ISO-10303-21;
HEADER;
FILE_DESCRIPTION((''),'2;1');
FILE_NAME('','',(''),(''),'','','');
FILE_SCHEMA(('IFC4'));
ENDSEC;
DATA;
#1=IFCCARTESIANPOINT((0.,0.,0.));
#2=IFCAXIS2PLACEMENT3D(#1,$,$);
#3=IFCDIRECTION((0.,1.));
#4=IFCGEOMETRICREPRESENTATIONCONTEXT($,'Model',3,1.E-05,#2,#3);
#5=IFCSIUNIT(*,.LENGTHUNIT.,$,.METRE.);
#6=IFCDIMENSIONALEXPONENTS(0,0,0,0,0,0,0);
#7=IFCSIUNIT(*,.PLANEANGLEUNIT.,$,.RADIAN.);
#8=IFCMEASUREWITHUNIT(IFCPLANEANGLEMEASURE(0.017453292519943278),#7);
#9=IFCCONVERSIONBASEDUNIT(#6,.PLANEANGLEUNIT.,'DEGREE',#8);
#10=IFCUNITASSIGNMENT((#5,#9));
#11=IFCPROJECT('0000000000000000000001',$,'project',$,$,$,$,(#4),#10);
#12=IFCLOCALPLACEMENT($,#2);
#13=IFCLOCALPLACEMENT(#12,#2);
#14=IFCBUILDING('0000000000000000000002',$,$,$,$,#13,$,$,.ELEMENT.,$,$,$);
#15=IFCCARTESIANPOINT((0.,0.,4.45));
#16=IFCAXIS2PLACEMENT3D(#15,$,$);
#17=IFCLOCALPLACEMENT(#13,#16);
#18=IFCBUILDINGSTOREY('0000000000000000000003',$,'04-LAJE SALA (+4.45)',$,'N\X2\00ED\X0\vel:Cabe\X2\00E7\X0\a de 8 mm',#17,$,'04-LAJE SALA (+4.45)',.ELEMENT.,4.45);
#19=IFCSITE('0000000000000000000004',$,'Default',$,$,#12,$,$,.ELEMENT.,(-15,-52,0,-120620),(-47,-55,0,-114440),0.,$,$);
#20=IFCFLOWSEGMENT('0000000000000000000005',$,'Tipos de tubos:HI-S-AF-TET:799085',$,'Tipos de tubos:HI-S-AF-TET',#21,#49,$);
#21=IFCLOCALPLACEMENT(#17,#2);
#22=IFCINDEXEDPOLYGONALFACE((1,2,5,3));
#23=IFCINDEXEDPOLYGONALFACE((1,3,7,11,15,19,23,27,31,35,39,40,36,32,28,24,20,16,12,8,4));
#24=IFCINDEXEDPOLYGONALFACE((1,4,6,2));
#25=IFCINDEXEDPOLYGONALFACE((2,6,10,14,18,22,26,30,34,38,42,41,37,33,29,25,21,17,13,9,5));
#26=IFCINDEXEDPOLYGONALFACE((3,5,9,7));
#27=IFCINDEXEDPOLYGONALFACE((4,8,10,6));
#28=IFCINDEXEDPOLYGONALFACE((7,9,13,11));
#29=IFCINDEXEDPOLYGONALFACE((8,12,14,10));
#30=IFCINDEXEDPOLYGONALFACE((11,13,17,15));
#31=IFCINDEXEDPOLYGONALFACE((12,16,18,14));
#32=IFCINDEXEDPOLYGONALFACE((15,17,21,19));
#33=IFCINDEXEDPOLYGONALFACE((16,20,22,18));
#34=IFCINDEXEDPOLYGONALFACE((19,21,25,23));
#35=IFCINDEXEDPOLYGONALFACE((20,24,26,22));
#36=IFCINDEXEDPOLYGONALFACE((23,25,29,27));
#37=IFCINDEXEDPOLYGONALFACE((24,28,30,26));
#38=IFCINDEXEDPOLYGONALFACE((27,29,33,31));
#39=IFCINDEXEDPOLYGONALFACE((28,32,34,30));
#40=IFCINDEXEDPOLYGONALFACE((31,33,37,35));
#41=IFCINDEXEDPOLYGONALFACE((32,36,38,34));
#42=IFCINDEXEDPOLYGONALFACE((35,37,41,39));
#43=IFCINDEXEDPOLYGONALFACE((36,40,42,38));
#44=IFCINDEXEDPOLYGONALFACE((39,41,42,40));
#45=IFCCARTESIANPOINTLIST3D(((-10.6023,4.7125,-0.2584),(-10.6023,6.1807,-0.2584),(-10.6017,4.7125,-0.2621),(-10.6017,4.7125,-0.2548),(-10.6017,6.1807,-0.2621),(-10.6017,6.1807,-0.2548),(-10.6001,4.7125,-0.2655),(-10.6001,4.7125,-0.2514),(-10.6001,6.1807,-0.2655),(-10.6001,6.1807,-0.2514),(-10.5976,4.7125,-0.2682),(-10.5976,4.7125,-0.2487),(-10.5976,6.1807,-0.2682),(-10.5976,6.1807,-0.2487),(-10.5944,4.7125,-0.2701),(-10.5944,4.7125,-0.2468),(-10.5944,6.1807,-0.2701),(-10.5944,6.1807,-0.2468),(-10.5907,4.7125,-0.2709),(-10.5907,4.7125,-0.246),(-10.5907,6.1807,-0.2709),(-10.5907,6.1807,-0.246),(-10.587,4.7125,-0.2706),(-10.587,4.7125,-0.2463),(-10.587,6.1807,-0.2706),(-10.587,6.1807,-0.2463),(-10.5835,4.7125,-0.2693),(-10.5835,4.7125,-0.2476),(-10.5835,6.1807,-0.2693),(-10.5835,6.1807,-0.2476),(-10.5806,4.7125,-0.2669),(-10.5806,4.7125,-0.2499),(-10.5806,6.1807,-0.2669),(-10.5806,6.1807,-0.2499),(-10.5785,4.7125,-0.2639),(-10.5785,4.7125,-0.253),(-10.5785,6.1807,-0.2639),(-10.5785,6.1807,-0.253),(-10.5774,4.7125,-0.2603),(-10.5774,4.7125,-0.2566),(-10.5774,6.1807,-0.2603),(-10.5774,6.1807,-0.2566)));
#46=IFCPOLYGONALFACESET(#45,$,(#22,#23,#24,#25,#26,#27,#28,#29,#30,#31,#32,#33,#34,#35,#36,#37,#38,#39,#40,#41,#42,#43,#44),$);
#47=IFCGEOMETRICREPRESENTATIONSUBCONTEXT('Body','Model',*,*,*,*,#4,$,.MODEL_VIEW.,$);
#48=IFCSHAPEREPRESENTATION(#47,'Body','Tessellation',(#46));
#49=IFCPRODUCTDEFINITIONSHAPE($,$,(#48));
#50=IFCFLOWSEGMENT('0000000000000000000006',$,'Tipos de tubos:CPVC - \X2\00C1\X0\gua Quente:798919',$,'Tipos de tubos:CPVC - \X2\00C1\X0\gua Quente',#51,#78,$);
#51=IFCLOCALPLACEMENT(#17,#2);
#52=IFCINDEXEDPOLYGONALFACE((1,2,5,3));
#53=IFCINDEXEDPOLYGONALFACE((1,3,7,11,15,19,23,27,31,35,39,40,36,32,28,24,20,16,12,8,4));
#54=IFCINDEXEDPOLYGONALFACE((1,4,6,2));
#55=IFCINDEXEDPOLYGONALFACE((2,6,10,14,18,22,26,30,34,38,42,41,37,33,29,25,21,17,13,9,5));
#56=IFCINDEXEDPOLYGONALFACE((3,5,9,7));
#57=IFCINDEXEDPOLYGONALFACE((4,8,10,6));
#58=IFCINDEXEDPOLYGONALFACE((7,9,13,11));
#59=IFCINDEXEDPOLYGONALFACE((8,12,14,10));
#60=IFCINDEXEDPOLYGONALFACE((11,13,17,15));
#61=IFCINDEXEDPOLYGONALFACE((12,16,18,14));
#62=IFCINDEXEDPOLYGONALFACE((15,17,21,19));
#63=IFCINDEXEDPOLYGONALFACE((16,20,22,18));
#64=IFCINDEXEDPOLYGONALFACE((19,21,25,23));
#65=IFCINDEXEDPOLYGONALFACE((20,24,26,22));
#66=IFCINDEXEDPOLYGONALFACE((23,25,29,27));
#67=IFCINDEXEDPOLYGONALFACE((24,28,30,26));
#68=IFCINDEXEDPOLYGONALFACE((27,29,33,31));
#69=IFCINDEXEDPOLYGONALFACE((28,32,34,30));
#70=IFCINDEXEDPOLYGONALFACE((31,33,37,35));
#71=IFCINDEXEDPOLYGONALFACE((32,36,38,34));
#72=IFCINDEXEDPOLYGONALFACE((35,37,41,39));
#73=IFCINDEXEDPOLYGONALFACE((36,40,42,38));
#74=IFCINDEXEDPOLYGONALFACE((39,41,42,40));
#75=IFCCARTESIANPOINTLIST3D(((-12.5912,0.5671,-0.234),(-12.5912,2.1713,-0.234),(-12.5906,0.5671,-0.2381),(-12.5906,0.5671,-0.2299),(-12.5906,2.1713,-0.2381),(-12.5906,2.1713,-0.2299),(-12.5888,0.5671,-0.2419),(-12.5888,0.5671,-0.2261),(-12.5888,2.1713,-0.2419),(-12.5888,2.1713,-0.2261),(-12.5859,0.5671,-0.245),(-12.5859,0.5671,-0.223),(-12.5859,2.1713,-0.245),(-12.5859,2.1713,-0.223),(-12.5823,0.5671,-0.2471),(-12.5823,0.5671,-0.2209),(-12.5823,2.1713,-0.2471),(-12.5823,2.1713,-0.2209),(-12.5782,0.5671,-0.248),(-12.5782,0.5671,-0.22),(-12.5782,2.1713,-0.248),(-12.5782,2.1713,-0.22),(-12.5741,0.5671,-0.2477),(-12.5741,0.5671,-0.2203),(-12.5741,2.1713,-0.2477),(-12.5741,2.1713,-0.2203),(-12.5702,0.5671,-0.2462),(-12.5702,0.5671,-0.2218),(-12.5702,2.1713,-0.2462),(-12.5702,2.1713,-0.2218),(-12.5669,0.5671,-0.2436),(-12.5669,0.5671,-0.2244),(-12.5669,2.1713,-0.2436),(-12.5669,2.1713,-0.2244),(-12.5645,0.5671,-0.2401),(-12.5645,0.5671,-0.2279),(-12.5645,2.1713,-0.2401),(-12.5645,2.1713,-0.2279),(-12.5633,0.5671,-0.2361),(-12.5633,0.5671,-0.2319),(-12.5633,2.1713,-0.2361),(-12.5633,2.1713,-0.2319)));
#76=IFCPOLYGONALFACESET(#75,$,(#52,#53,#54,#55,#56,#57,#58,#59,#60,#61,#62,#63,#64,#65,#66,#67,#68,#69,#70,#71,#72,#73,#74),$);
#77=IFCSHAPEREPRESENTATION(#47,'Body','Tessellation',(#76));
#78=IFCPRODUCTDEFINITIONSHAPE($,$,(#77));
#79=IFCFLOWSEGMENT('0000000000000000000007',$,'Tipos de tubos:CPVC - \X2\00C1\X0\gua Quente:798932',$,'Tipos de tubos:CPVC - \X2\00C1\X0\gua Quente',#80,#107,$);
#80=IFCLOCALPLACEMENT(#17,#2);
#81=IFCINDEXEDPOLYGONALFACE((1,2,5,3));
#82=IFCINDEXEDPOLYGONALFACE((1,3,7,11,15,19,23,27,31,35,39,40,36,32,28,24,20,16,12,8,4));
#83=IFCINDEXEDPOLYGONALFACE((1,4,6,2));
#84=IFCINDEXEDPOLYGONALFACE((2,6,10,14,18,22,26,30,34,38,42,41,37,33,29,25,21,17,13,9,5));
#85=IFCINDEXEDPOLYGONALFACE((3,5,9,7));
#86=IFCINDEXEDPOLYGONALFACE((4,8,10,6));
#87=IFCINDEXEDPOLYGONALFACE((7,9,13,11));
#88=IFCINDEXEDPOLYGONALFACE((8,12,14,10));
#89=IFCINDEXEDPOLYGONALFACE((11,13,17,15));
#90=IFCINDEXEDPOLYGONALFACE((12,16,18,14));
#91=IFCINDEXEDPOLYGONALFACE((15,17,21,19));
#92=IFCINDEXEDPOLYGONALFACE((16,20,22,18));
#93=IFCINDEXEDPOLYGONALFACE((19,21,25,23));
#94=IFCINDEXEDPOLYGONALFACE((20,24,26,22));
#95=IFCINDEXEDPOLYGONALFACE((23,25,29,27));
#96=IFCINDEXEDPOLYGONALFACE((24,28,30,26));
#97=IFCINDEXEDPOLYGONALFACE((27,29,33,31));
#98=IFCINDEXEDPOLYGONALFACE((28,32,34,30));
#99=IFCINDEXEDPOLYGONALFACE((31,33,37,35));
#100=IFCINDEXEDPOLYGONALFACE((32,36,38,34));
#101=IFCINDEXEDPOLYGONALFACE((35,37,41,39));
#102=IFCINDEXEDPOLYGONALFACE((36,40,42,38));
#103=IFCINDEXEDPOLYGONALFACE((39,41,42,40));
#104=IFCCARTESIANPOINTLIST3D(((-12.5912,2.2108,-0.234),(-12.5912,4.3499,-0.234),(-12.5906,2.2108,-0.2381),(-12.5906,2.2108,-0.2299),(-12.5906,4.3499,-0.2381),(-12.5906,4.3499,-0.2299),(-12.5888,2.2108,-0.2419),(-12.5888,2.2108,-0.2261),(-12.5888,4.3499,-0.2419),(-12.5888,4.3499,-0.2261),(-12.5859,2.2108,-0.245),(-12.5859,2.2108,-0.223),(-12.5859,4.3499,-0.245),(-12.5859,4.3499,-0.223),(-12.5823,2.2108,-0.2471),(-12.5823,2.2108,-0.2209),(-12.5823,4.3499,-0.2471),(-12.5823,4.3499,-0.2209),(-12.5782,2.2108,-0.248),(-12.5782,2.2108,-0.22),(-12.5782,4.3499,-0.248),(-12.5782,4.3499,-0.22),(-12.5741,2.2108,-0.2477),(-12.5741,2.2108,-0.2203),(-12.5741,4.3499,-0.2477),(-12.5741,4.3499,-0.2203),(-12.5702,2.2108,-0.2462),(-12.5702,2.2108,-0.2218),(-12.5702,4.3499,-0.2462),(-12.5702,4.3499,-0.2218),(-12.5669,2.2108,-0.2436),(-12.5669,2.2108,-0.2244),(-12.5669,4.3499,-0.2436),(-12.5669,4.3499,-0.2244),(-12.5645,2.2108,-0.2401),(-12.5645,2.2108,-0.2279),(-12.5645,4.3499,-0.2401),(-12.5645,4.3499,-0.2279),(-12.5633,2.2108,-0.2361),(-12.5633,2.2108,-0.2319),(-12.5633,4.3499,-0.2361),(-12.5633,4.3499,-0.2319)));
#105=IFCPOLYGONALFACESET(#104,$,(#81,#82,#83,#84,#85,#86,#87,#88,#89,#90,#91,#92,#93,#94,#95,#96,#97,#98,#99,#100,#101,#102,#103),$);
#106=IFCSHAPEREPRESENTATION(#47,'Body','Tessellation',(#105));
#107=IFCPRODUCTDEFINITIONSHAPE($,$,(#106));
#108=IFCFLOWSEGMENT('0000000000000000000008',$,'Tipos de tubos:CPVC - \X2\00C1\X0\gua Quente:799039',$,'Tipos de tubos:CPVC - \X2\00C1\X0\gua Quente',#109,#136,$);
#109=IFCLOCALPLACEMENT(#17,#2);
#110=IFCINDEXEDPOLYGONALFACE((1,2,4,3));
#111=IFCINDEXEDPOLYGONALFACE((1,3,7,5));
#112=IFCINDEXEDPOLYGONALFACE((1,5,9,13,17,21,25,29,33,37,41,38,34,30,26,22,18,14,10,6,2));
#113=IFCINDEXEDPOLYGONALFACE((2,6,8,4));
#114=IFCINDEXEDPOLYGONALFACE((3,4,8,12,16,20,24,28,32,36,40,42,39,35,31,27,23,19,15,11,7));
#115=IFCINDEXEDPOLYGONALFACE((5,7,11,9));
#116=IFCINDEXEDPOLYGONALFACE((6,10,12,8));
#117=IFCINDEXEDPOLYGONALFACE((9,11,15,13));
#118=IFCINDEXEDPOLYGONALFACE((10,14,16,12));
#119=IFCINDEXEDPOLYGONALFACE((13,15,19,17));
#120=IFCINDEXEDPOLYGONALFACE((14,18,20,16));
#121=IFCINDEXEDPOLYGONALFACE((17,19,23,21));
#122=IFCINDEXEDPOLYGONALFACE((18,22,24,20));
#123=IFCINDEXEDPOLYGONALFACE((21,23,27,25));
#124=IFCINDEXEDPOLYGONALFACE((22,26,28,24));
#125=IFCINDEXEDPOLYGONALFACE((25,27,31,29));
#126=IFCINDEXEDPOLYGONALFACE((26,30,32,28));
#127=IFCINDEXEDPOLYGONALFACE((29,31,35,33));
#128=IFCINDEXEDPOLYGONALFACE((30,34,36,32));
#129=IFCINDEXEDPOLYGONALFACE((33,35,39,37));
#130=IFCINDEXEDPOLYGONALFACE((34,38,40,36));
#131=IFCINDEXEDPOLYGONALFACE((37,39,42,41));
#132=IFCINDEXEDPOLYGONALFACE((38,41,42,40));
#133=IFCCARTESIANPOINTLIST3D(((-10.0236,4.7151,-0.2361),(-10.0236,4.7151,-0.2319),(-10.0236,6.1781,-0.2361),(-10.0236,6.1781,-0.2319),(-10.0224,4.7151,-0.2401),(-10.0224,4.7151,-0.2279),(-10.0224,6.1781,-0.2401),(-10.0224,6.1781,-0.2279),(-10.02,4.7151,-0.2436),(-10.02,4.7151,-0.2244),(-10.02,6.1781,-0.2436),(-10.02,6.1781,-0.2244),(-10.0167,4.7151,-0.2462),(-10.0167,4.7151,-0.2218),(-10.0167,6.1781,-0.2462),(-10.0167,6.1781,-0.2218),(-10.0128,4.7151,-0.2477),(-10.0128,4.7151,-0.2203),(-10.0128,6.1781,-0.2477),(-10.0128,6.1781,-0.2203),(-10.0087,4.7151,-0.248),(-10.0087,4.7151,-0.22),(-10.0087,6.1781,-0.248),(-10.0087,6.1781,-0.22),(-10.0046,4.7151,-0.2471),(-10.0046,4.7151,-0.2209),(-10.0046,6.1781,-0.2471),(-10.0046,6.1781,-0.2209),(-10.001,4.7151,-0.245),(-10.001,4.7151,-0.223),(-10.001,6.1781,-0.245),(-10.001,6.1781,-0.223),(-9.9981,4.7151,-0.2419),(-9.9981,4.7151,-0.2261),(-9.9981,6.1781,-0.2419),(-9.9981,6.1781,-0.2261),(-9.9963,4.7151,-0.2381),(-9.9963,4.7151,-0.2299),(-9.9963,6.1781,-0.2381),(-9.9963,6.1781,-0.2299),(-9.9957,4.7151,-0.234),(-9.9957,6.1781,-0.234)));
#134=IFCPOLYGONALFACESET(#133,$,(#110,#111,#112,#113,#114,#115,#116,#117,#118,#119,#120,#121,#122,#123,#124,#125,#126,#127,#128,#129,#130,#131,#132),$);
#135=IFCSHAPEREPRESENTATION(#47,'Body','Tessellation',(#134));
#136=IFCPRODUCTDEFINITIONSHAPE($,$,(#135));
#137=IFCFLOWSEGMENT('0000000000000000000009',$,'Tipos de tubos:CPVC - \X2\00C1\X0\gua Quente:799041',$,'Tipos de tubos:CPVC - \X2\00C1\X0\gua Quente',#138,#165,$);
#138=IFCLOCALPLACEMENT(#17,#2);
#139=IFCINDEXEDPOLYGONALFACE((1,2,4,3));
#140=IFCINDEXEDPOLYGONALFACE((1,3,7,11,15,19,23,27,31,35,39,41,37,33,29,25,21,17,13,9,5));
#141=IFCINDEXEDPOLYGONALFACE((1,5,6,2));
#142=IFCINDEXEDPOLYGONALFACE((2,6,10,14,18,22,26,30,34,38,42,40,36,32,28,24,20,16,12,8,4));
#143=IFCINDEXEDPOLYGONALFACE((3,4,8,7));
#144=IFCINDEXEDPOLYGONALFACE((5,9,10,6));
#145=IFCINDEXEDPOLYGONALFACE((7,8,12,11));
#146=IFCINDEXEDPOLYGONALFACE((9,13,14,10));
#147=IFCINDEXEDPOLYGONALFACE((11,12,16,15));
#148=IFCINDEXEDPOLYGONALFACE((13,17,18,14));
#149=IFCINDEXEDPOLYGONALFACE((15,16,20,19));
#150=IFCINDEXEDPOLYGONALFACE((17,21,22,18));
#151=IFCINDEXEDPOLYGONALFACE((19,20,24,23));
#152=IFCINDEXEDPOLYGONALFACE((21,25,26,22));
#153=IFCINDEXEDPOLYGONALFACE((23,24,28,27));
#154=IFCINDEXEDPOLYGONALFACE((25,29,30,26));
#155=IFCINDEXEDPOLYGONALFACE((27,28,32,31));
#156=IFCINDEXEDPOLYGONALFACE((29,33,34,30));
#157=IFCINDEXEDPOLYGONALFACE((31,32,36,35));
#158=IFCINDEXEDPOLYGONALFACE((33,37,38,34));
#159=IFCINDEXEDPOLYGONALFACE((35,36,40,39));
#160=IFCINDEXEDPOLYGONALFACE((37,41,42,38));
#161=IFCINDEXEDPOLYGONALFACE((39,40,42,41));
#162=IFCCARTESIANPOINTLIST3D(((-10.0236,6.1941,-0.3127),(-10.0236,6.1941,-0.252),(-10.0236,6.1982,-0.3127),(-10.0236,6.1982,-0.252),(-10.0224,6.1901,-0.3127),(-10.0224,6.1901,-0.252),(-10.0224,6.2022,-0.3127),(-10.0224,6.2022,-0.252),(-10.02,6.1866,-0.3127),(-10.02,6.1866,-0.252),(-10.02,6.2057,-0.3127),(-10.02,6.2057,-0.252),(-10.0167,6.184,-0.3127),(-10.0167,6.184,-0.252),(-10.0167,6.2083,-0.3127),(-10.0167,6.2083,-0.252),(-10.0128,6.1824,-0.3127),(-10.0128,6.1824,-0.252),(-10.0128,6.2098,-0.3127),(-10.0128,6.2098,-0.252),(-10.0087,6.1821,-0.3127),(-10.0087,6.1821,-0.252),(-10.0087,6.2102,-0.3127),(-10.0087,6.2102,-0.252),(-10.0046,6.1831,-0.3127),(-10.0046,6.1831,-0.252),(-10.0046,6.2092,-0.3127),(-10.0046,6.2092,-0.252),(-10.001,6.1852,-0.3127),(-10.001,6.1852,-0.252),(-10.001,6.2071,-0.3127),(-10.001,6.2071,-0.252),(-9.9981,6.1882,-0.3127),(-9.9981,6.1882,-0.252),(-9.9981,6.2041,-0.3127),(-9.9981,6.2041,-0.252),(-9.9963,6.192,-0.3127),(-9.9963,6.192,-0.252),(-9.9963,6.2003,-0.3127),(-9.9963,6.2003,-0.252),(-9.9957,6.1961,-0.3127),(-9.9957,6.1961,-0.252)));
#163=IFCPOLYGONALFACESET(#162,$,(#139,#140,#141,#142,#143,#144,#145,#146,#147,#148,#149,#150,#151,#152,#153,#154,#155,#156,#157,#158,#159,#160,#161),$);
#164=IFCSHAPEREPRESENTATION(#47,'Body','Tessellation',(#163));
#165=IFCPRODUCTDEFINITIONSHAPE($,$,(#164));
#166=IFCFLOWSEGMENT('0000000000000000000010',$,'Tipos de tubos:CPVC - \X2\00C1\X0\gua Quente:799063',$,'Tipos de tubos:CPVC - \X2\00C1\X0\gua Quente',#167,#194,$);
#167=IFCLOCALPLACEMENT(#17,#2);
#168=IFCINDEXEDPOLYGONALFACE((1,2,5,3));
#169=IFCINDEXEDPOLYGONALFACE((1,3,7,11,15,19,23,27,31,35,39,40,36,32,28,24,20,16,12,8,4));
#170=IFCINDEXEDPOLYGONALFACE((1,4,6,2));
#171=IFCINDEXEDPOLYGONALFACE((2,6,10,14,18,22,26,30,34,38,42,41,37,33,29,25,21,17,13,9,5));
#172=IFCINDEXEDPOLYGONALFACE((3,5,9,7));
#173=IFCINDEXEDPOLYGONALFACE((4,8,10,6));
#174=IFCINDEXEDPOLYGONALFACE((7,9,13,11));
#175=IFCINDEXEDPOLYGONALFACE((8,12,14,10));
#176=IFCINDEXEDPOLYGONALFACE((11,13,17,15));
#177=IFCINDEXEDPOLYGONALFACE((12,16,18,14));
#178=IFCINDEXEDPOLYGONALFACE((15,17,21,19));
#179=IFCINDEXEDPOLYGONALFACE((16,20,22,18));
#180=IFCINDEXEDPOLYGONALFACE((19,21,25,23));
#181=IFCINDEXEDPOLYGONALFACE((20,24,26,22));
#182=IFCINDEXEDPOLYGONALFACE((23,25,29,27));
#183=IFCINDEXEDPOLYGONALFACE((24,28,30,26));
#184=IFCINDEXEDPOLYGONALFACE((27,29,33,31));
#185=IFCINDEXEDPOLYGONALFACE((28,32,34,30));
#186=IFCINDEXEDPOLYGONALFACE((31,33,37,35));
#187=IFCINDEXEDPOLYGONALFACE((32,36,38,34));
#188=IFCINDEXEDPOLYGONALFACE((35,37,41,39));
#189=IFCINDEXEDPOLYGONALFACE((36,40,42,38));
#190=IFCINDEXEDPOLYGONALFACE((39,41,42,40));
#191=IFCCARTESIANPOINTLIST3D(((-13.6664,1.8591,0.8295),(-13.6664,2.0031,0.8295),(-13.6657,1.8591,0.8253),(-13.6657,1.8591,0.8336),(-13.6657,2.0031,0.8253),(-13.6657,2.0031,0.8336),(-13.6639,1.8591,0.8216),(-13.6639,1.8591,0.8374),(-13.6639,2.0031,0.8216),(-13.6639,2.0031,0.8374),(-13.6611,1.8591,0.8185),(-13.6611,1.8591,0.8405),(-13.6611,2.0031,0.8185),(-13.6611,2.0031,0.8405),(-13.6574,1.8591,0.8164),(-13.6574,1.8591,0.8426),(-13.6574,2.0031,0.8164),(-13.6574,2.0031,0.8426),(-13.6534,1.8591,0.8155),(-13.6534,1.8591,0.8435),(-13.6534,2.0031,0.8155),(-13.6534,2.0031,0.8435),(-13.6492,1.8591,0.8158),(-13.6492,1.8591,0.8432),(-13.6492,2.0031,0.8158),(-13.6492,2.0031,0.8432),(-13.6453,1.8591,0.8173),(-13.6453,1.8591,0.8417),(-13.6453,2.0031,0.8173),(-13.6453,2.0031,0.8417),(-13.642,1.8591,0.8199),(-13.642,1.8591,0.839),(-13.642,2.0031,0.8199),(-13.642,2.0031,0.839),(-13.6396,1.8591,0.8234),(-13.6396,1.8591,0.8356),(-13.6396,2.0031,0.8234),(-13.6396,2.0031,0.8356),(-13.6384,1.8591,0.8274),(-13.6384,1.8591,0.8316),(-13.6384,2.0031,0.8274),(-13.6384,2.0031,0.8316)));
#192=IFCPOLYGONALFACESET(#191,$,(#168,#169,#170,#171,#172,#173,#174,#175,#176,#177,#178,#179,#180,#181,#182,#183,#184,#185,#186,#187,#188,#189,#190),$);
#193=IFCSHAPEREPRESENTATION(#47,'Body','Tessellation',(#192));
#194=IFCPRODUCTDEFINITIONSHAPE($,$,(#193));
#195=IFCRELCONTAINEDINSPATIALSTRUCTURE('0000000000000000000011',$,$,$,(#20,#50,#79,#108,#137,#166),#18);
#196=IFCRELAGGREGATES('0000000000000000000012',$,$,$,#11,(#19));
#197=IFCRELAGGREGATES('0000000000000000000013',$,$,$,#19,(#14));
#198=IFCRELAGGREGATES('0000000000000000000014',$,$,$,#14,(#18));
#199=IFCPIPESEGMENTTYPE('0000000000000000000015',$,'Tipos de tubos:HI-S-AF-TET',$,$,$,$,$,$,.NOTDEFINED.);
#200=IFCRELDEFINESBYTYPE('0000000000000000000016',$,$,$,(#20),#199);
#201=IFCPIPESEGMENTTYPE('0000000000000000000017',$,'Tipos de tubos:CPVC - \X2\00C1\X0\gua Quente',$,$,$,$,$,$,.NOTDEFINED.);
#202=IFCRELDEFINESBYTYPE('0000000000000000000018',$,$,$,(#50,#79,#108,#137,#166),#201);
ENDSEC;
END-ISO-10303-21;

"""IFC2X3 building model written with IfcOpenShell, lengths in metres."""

from ifc_helpers import new_model, entity, si_unit, converted_unit, direction, frame, frame_2d, origin, origin_2d_with_axis, place, context, subcontext, project, spatial, circle, extrude, type_object, element, save


model = new_model("IFC2X3")

# Units and contexts
model_context = context("Model", 3, precision=1e-05, world=origin(), true_north=direction((0.0, 1.0)))
body_context = subcontext(model_context, "Body", "Model", "MODEL_VIEW")
ifc_project = project(units=[si_unit("LENGTHUNIT", "METRE"), converted_unit("PLANEANGLEUNIT", "DEGREE", entity("IfcPlaneAngleMeasure", 0.017453292519943278), si_unit("PLANEANGLEUNIT", "RADIAN"), dimensions=[0, 0, 0, 0, 0, 0, 0])], contexts=[model_context])

# Site, building, storey
site_placement = place(None, origin())
site = spatial("IfcSite", under=ifc_project, at=site_placement, Name="Default", CompositionType="ELEMENT", RefLatitude=(-15, -52, 0, -120620), RefLongitude=(-47, -55, 0, -114440), RefElevation=0.0)
building_placement = place(site_placement, origin())
building = spatial("IfcBuilding", under=site, at=building_placement, CompositionType="ELEMENT")
storey_placement = place(building_placement, frame((0.0, 0.0, 4.45)))
storey = spatial("IfcBuildingStorey", under=building, at=storey_placement, Name="04-LAJE SALA (+4.45)", ObjectType="Nível:Cabeça de 8 mm", LongName="04-LAJE SALA (+4.45)", CompositionType="ELEMENT", Elevation=4.45)

# Flow segments
pipe_segment_type_1 = type_object("IfcPipeSegmentType", Name="Tipos de tubos:HI-S-AF-TET", PredefinedType="NOTDEFINED")
flow_segment_1_placement = place(storey_placement, origin())
element("IfcFlowSegment", 1, at=flow_segment_1_placement, inside=storey, type_object=pipe_segment_type_1, Name="Tipos de tubos:HI-S-AF-TET:799085", ObjectType="Tipos de tubos:HI-S-AF-TET", context=body_context, shape_type="SweptSolid", body=[
    extrude(circle(Radius=0.0125, at=origin_2d_with_axis()), frame((-10.5898, 4.7125, -0.2584), z_axis=(0.0, 1.0, 0.0), x_axis=(-1.0, 0.0, 0.0)), (0.0, 0.0, 1.0), 1.4681),
])
pipe_segment_type_2 = type_object("IfcPipeSegmentType", Name="Tipos de tubos:CPVC - Água Quente", PredefinedType="NOTDEFINED")
flow_segment_2_placement = place(storey_placement, origin())
element("IfcFlowSegment", 2, at=flow_segment_2_placement, inside=storey, type_object=pipe_segment_type_2, Name="Tipos de tubos:CPVC - Água Quente:798919", ObjectType="Tipos de tubos:CPVC - Água Quente", context=body_context, shape_type="SweptSolid", body=[
    extrude(circle(Radius=0.0141, at=origin_2d_with_axis()), frame((-12.5772, 0.5671, -0.234), z_axis=(0.0, 1.0, 0.0), x_axis=(-1.0, 0.0, 0.0)), (0.0, 0.0, 1.0), 1.6042),
])
flow_segment_3_placement = place(storey_placement, origin())
element("IfcFlowSegment", 3, at=flow_segment_3_placement, inside=storey, type_object=pipe_segment_type_2, Name="Tipos de tubos:CPVC - Água Quente:798932", ObjectType="Tipos de tubos:CPVC - Água Quente", context=body_context, shape_type="SweptSolid", body=[
    extrude(circle(Radius=0.0141, at=origin_2d_with_axis()), frame((-12.5772, 2.2108, -0.234), z_axis=(0.0, 1.0, 0.0), x_axis=(-1.0, 0.0, 0.0)), (0.0, 0.0, 1.0), 2.1391),
])
flow_segment_4_placement = place(storey_placement, origin())
element("IfcFlowSegment", 4, at=flow_segment_4_placement, inside=storey, type_object=pipe_segment_type_2, Name="Tipos de tubos:CPVC - Água Quente:799039", ObjectType="Tipos de tubos:CPVC - Água Quente", context=body_context, shape_type="SweptSolid", body=[
    extrude(circle(Radius=0.0141, at=origin_2d_with_axis()), frame((-10.0097, 4.7151, -0.234), z_axis=(0.0, 1.0, 0.0), x_axis=(1.0, 0.0, 0.0)), (0.0, 0.0, 1.0), 1.463),
])
flow_segment_5_placement = place(storey_placement, origin())
element("IfcFlowSegment", 5, at=flow_segment_5_placement, inside=storey, type_object=pipe_segment_type_2, Name="Tipos de tubos:CPVC - Água Quente:799041", ObjectType="Tipos de tubos:CPVC - Água Quente", context=body_context, shape_type="SweptSolid", body=[
    extrude(circle(Radius=0.0141, at=origin_2d_with_axis()), frame((-10.0097, 6.1961, -0.3127)), (0.0, 0.0, 1.0), 0.0607),
])
flow_segment_6_placement = place(storey_placement, origin())
element("IfcFlowSegment", 6, at=flow_segment_6_placement, inside=storey, type_object=pipe_segment_type_2, Name="Tipos de tubos:CPVC - Água Quente:799063", ObjectType="Tipos de tubos:CPVC - Água Quente", context=body_context, shape_type="SweptSolid", body=[
    extrude(circle(Radius=0.0141, at=frame_2d((0.0, 0.0), x_axis=(1.0, 0.0))), frame((-13.6523, 1.8591, 0.8295), z_axis=(0.0, 1.0, 0.0), x_axis=(-1.0, 0.0, 0.0)), (0.0, 0.0, 1.0), 0.144),
])

save(model, "model.ifc")
